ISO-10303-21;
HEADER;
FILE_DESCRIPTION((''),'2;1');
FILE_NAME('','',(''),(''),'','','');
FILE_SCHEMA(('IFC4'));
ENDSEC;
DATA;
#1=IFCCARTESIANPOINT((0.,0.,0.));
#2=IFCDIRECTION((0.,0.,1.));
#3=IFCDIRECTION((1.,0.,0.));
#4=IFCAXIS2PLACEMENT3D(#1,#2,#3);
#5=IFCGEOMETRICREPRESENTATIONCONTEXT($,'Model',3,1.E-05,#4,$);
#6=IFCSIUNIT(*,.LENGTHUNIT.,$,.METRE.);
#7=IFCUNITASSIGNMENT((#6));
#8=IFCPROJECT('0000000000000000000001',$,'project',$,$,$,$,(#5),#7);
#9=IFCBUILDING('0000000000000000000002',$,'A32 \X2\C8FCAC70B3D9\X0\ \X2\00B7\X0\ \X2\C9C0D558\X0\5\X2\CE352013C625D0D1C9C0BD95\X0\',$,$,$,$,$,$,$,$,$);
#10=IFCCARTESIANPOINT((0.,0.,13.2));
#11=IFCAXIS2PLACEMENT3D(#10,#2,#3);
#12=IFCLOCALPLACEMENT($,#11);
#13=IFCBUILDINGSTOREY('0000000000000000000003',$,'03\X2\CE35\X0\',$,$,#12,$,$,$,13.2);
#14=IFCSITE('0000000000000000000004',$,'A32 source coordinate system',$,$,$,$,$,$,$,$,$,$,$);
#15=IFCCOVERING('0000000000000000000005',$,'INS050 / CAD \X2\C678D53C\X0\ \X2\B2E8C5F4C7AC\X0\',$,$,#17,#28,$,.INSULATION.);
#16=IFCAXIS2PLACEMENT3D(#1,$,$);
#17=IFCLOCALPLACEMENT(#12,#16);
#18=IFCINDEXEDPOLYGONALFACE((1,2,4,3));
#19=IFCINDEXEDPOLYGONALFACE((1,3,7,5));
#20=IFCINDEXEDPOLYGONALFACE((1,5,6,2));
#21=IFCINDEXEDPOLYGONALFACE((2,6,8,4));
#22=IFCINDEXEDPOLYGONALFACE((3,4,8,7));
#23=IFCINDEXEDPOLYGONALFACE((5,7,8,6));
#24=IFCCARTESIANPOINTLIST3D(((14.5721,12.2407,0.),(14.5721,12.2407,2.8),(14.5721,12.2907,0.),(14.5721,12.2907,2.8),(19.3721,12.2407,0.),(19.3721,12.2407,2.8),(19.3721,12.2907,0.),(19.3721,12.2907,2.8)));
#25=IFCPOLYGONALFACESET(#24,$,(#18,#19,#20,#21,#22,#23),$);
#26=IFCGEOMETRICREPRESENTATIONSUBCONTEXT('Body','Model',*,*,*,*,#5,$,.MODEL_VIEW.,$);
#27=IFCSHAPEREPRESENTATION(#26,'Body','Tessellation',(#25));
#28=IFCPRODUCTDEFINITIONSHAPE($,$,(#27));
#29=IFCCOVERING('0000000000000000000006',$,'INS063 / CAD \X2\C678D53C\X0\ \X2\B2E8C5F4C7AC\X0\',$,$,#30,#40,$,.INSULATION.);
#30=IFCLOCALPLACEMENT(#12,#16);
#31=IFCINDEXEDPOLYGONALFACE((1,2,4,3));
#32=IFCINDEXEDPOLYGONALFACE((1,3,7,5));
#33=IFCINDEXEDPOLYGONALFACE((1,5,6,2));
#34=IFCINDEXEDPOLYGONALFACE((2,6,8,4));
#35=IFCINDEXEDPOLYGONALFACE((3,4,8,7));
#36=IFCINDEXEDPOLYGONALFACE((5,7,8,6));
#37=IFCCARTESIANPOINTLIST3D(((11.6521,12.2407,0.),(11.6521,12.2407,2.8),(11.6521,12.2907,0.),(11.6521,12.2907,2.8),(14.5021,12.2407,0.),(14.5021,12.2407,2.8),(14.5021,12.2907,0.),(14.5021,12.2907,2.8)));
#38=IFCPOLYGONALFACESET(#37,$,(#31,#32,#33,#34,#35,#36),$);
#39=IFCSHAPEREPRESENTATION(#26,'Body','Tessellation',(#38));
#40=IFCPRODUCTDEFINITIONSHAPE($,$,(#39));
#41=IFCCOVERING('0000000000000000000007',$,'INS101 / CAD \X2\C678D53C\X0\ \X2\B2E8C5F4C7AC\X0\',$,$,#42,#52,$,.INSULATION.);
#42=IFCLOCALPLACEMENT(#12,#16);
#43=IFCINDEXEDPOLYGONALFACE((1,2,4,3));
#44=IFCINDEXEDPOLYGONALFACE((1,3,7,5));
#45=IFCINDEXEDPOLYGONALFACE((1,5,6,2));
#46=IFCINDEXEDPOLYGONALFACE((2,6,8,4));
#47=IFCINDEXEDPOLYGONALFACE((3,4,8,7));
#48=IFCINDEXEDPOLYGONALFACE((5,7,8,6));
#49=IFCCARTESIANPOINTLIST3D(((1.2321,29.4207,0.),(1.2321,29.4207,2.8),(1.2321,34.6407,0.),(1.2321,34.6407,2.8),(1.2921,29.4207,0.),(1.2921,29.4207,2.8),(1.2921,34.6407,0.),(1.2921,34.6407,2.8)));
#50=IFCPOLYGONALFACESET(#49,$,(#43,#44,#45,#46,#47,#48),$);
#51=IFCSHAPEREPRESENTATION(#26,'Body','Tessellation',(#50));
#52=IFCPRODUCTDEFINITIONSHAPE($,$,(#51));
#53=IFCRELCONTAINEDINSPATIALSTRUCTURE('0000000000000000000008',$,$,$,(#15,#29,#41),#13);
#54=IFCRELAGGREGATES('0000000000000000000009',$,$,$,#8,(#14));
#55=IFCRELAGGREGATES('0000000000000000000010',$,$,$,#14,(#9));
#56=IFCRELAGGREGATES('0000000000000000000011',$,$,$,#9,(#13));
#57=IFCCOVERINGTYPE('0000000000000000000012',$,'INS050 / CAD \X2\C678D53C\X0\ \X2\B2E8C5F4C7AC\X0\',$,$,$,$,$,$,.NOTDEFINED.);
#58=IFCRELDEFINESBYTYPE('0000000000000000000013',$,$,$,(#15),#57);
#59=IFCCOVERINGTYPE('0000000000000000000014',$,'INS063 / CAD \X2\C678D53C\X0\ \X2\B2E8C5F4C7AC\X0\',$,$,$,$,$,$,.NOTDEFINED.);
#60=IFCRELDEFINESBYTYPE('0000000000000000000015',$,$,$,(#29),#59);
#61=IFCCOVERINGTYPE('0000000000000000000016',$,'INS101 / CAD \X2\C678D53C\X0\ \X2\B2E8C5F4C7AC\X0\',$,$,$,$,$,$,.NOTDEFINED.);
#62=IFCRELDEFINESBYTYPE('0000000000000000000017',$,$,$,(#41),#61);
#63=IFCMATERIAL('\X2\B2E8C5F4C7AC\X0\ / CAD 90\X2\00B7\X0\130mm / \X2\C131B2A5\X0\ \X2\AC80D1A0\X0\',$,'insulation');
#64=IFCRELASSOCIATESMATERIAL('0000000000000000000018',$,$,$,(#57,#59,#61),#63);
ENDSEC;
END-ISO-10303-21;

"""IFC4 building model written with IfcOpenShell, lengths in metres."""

from ifc_helpers import new_model, si_unit, frame, origin, origin_with_axes, place, context, subcontext, project, spatial, polyline, outline, extrude, source, transform, mapped, material, type_object, type_shapes, element, save


model = new_model("IFC4")

# Units and contexts
model_context = context("Model", 3, precision=1e-05, world=origin_with_axes())
body_context = subcontext(model_context, "Body", "Model", "MODEL_VIEW")
ifc_project = project(units=[si_unit("LENGTHUNIT", "METRE")], contexts=[model_context])

# Site, building, storey
site = spatial("IfcSite", under=ifc_project, Name="A32 source coordinate system")
building = spatial("IfcBuilding", under=site, Name="A32 주거동 · 지하5층–옥탑지붕")
storey_placement = place(None, frame((0.0, 0.0, 13.2), z_axis=(0.0, 0.0, 1.0), x_axis=(1.0, 0.0, 0.0)))
storey = spatial("IfcBuildingStorey", under=building, at=storey_placement, Name="03층", Elevation=13.2)

# Coverings
ifc_material = material(Name="단열재 / CAD 90·130mm / 성능 검토", Category="insulation")
covering_type_1 = type_object("IfcCoveringType", Name="INS050 / CAD 외피 단열재", PredefinedType="NOTDEFINED", material=ifc_material)
shared_shape_1 = source(origin(), body_context, "Body", "SweptSolid", [
    extrude(outline(polyline([(14.5721, 12.2407), (14.5721, 12.2907), (19.3721, 12.2907), (19.3721, 12.2407), (14.5721, 12.2407)])), origin(), (0.0, 0.0, 1.0), 2.8),
])
type_shapes(covering_type_1, [shared_shape_1])
covering_1_placement = place(storey_placement, origin_with_axes())
element("IfcCovering", 1, at=covering_1_placement, inside=storey, type_object=covering_type_1, Name="INS050 / CAD 외피 단열재", PredefinedType="INSULATION", context=body_context, shape_type="MappedRepresentation", body=[
    mapped(shared_shape_1, transform((0.0, 0.0, 0.0), scale=1.0)),
])
covering_type_2 = type_object("IfcCoveringType", Name="INS063 / CAD 외피 단열재", PredefinedType="NOTDEFINED", material=ifc_material)
shared_shape_2 = source(origin(), body_context, "Body", "SweptSolid", [
    extrude(outline(polyline([(14.5021, 12.2407), (11.6521, 12.2407), (11.6521, 12.2907), (14.5021, 12.2907), (14.5021, 12.2407)])), origin(), (0.0, 0.0, 1.0), 2.8),
])
type_shapes(covering_type_2, [shared_shape_2])
covering_2_placement = place(storey_placement, origin_with_axes())
element("IfcCovering", 2, at=covering_2_placement, inside=storey, type_object=covering_type_2, Name="INS063 / CAD 외피 단열재", PredefinedType="INSULATION", context=body_context, shape_type="MappedRepresentation", body=[
    mapped(shared_shape_2, transform((0.0, 0.0, 0.0), scale=1.0)),
])
covering_type_3 = type_object("IfcCoveringType", Name="INS101 / CAD 외피 단열재", PredefinedType="NOTDEFINED", material=ifc_material)
shared_shape_3 = source(origin(), body_context, "Body", "SweptSolid", [
    extrude(outline(polyline([(1.2321, 29.4207), (1.2321, 34.6407), (1.2921, 34.6407), (1.2921, 29.4207), (1.2321, 29.4207)])), origin(), (0.0, 0.0, 1.0), 2.8),
])
type_shapes(covering_type_3, [shared_shape_3])
covering_3_placement = place(storey_placement, origin_with_axes())
element("IfcCovering", 3, at=covering_3_placement, inside=storey, type_object=covering_type_3, Name="INS101 / CAD 외피 단열재", PredefinedType="INSULATION", context=body_context, shape_type="MappedRepresentation", body=[
    mapped(shared_shape_3, transform((0.0, 0.0, 0.0), scale=1.0)),
])

save(model, "model.ifc")
